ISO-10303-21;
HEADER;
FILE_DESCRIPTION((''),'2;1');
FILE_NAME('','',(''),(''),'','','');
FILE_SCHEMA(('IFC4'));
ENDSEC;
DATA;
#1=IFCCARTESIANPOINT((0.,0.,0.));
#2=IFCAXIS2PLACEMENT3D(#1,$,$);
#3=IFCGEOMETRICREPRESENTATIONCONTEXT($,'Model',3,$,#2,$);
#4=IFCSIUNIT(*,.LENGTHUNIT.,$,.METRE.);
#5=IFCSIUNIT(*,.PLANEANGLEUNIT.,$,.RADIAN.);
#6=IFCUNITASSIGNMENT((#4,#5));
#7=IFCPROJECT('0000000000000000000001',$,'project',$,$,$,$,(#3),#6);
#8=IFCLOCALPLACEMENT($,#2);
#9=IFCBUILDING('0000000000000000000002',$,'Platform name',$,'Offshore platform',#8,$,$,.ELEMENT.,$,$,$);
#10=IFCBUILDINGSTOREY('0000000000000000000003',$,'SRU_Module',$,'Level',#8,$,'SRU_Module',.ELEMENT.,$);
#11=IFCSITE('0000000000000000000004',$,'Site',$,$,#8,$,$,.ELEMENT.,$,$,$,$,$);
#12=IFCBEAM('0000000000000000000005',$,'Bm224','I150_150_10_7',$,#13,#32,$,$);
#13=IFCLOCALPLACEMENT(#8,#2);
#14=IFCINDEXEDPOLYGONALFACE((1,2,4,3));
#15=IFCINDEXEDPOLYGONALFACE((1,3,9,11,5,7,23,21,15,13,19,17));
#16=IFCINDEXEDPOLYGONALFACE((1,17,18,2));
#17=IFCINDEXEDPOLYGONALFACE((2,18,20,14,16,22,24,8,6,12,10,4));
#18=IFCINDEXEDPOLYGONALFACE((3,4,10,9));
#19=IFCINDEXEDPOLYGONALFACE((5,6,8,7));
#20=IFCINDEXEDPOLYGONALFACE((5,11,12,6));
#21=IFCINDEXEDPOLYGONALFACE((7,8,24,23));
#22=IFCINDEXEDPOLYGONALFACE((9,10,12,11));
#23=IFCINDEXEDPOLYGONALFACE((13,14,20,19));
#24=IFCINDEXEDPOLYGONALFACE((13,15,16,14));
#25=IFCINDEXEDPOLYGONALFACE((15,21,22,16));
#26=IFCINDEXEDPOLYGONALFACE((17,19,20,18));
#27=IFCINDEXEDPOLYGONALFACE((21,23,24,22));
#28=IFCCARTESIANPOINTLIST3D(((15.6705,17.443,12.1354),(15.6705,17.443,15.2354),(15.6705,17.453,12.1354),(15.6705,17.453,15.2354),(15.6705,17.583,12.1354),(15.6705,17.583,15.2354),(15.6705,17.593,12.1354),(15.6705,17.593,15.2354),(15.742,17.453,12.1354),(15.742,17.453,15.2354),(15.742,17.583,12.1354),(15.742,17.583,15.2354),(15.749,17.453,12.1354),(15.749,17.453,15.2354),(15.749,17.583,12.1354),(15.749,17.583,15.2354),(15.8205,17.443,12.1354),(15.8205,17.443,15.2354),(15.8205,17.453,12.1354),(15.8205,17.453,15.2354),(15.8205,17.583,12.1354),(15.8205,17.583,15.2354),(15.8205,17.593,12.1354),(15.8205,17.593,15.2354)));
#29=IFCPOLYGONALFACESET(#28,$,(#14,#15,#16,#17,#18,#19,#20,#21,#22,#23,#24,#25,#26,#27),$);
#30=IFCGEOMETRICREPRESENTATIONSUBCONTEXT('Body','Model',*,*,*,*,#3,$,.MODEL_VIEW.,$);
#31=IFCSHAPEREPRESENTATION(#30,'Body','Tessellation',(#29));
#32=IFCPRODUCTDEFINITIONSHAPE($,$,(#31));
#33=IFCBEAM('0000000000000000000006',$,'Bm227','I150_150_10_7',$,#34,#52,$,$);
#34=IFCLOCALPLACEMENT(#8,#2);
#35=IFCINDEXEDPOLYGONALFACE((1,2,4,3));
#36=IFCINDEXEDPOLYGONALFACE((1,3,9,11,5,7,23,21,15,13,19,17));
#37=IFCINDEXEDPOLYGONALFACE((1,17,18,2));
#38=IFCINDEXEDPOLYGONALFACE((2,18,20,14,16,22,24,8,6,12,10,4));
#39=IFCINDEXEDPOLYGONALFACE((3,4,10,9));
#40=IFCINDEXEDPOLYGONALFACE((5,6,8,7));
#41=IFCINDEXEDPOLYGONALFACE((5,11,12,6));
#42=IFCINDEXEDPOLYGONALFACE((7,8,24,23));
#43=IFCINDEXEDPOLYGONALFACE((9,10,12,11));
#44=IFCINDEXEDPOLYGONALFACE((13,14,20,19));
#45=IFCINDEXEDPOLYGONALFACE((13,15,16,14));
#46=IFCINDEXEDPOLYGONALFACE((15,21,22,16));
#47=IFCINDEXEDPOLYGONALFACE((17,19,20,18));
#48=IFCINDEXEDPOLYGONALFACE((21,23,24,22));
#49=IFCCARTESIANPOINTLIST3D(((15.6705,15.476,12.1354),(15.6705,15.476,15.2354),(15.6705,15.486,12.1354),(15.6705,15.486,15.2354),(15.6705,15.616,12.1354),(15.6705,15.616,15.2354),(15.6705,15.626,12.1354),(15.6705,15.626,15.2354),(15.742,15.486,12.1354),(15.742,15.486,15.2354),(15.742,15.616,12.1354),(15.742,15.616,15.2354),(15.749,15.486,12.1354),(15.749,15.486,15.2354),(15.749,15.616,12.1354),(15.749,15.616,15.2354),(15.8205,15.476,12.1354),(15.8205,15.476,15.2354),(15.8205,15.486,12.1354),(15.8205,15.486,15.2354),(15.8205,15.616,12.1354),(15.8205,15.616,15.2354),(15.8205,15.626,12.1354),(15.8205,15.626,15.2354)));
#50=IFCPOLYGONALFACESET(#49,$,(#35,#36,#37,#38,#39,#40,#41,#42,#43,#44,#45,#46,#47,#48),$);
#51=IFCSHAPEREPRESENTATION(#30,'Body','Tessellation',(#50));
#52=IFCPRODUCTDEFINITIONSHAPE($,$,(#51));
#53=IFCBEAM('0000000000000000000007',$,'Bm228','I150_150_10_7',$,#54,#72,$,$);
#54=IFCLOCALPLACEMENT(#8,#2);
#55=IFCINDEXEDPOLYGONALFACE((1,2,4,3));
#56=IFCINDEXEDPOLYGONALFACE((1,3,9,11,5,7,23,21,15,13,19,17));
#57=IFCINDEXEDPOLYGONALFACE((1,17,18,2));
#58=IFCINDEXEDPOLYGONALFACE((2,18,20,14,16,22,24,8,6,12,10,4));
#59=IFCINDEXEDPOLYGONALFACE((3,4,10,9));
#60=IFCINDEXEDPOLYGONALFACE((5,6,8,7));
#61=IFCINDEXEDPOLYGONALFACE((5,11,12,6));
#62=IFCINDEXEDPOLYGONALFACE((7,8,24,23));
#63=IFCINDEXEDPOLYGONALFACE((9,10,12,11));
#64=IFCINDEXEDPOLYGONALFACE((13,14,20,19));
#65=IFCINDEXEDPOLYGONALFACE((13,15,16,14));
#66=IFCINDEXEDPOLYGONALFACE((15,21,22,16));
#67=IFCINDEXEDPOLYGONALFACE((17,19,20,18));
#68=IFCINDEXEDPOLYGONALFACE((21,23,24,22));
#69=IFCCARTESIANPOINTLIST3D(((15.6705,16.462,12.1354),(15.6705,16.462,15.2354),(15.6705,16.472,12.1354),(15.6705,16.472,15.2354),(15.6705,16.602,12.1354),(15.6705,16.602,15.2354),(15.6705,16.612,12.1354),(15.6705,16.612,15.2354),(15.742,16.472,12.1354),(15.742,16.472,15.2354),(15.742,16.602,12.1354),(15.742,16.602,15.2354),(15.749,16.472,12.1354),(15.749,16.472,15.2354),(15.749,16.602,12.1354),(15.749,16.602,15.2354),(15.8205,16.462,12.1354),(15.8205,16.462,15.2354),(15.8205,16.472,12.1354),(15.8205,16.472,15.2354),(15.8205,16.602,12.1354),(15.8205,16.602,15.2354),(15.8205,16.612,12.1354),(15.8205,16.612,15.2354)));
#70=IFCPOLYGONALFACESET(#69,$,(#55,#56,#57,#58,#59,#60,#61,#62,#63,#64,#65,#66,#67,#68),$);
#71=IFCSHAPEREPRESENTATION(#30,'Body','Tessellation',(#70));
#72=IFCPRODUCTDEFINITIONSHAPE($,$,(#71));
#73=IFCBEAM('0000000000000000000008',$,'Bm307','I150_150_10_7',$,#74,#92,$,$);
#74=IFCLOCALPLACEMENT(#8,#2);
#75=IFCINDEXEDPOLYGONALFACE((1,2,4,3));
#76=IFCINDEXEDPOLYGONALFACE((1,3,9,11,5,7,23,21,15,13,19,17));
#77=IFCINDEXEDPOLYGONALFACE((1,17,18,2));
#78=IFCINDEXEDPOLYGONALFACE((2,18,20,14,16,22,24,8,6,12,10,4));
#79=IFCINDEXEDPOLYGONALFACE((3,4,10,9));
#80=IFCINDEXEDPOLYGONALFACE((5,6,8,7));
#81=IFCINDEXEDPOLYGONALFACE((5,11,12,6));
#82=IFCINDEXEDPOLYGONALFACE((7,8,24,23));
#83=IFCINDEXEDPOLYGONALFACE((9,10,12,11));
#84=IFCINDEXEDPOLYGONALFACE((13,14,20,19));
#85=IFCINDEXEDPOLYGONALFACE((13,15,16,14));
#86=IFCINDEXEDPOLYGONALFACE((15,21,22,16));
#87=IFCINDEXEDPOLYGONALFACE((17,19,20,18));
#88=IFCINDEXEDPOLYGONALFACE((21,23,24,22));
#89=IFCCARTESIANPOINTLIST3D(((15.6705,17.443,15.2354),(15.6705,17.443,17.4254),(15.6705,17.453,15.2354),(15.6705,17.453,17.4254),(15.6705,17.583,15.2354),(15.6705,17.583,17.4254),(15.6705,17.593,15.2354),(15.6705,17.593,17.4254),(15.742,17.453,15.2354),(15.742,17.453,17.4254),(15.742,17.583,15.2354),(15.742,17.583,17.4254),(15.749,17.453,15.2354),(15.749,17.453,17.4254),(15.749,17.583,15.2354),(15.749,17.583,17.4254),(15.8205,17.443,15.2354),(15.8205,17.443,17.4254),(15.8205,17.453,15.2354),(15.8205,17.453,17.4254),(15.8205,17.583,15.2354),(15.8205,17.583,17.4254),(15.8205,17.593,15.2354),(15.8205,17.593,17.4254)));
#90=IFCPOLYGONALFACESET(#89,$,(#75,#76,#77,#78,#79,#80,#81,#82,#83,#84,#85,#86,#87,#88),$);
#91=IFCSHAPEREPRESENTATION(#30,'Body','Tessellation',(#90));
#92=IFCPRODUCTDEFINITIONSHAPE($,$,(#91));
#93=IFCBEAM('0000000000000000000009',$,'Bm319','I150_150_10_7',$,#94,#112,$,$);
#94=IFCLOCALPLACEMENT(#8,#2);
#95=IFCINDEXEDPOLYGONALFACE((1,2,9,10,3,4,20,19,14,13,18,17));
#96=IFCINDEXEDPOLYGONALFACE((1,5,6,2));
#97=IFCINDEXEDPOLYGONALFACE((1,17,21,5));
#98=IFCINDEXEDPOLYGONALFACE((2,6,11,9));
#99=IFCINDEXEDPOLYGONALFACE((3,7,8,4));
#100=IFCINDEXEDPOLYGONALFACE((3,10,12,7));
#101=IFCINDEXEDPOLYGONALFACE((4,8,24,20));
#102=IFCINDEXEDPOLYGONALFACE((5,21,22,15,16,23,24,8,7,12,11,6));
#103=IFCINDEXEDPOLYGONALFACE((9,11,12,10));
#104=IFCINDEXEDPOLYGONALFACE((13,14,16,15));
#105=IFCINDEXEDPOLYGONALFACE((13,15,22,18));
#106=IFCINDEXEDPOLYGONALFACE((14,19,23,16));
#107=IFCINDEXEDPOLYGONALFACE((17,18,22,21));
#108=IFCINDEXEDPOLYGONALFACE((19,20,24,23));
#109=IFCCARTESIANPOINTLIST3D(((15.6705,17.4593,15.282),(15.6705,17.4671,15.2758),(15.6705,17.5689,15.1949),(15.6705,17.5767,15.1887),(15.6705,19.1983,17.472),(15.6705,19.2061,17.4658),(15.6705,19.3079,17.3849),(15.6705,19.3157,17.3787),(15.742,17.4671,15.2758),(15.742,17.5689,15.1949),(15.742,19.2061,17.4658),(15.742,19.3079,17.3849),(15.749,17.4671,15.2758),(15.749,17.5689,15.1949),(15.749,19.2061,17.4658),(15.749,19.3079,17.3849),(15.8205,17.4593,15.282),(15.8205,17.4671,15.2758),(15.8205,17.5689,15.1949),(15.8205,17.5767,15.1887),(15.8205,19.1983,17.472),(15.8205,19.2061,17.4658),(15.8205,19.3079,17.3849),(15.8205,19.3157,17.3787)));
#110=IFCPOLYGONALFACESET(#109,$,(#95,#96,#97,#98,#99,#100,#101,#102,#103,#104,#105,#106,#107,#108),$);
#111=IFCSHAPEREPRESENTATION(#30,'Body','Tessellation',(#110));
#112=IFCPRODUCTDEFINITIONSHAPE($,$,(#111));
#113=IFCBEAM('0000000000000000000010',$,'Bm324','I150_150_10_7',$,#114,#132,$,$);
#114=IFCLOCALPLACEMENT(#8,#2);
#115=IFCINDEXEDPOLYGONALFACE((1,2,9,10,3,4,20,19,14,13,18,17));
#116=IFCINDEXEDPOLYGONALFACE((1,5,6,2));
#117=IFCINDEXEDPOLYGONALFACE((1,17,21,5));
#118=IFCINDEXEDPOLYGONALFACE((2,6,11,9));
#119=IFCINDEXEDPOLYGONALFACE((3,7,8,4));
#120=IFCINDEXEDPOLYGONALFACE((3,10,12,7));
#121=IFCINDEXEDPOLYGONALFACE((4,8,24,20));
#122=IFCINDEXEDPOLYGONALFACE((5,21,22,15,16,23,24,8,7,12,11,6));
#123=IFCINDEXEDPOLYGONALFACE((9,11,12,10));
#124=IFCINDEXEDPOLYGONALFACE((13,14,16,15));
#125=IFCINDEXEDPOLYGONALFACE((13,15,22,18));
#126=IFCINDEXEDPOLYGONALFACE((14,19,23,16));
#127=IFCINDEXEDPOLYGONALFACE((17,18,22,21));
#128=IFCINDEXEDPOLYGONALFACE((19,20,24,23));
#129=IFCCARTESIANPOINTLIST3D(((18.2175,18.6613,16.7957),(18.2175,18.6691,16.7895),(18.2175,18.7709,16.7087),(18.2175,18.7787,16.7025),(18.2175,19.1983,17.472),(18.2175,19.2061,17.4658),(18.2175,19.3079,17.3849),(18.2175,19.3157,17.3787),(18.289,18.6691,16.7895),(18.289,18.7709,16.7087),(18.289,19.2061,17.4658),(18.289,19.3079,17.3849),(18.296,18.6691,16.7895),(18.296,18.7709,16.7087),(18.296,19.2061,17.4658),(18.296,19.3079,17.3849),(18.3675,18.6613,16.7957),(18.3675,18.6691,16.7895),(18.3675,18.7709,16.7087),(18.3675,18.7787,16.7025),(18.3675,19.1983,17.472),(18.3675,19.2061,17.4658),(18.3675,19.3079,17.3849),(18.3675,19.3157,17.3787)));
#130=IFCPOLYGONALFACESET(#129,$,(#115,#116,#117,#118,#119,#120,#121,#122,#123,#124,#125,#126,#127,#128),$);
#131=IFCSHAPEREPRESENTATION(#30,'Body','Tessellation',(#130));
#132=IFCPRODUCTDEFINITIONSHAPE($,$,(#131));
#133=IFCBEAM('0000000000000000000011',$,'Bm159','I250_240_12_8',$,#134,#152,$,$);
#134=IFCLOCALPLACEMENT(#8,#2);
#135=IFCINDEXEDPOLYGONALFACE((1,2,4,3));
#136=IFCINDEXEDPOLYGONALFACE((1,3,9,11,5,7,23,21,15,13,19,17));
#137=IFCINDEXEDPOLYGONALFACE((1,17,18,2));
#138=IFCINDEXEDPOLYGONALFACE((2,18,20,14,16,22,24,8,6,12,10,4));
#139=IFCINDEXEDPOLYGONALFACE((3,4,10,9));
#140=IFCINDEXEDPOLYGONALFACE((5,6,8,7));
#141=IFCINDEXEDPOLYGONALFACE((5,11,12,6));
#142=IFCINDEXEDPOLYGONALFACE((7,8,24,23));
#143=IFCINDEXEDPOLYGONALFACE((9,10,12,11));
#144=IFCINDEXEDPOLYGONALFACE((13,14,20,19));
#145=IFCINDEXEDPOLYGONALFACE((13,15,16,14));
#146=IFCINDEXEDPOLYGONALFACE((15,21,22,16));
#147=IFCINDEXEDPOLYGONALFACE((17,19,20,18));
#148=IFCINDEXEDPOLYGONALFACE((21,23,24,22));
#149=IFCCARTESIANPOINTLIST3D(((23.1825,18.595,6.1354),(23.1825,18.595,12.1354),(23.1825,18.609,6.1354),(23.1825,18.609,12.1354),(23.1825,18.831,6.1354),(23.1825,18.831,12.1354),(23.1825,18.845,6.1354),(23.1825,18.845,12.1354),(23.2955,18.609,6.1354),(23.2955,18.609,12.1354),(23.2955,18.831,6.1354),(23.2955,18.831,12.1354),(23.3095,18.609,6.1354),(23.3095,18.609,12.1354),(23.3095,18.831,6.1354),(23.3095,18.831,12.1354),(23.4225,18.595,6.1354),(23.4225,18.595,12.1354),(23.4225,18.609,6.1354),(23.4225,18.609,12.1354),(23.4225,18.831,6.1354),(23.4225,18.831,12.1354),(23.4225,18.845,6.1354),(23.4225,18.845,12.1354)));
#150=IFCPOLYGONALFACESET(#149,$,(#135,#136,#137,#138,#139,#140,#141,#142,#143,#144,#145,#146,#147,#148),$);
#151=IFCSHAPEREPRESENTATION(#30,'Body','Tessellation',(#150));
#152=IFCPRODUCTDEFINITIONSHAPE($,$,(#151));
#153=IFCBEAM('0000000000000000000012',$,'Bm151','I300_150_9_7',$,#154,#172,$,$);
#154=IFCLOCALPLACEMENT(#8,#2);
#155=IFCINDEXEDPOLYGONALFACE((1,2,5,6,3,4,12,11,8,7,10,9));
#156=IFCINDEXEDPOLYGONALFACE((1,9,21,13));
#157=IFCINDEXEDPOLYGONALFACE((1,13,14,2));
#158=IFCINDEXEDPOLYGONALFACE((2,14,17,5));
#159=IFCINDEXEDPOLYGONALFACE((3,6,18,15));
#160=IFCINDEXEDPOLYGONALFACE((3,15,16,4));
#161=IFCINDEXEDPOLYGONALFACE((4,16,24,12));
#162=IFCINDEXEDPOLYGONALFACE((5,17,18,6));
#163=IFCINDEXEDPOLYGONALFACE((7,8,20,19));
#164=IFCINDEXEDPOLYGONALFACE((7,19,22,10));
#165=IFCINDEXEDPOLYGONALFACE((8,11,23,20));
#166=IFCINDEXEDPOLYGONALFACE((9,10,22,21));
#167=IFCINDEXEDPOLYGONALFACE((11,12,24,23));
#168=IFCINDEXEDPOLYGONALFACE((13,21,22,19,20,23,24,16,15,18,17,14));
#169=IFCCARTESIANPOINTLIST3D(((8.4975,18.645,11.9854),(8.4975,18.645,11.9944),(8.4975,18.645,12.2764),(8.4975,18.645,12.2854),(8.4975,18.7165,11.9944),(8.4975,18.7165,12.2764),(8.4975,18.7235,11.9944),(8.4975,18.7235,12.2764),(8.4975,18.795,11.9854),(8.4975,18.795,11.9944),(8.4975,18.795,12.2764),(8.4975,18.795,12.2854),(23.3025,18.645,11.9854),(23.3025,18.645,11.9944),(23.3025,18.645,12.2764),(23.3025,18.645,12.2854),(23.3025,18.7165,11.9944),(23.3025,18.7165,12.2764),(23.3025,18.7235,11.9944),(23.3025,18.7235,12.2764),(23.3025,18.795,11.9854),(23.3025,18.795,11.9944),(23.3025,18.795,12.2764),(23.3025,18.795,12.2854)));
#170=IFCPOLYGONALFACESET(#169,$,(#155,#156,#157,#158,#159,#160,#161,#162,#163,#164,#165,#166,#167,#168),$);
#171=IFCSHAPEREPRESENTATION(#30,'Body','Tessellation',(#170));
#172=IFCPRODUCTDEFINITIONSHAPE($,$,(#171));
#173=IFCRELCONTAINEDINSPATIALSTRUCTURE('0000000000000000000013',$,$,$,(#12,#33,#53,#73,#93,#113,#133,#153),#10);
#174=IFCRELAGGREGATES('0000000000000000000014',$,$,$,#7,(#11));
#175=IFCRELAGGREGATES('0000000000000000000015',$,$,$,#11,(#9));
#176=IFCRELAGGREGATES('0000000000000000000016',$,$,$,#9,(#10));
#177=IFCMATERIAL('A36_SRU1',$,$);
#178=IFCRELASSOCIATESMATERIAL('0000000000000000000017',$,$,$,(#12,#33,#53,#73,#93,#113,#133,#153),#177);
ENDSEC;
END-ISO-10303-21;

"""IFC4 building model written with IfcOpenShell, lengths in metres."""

from ifc_helpers import new_model, si_unit, frame, origin, origin_with_axes, origin_2d, place, context, subcontext, project, spatial, i_section, extrude, source, transform, mapped, material, element, save


model = new_model("IFC4")

# Units and contexts
model_context = context("Model", 3, world=origin())
body_context = subcontext(model_context, "Body", "Model", "MODEL_VIEW")
ifc_project = project(units=[si_unit("LENGTHUNIT", "METRE"), si_unit("PLANEANGLEUNIT", "RADIAN")], contexts=[model_context])

# Site, building, storey
placement_1 = place(None, origin())
site = spatial("IfcSite", under=ifc_project, at=placement_1, Name="Site", CompositionType="ELEMENT")
building = spatial("IfcBuilding", under=site, at=placement_1, Name="Platform name", ObjectType="Offshore platform", CompositionType="ELEMENT")
storey = spatial("IfcBuildingStorey", under=building, at=placement_1, Name="SRU_Module", ObjectType="Level", LongName="SRU_Module", CompositionType="ELEMENT")

# Beams
ifc_material_1 = material(Name="A36_SRU1")
shared_shape_1 = source(origin(), body_context, "Body", "SweptSolid", [
    extrude(i_section(OverallWidth=0.15, OverallDepth=0.15, WebThickness=0.007, FlangeThickness=0.01, FilletRadius=0.0, at=origin_2d()), origin_with_axes(), (0.0, 0.0, 1.0), 3.1),
])
placement_2 = place(None, origin())
placement_3 = place(placement_2, origin())
placement_4 = place(placement_3, origin())
beam_1_placement = place(placement_4, frame((15.7455, 17.518, 12.1354)))
element("IfcBeam", 1, at=beam_1_placement, inside=storey, material=ifc_material_1, Name="Bm224", Description="I150_150_10_7", context=body_context, shape_type="MappedRepresentation", body=[
    mapped(shared_shape_1, transform((0.0, 0.0, 0.0), scale=1.0)),
])
shared_shape_2 = source(origin(), body_context, "Body", "SweptSolid", [
    extrude(i_section(OverallWidth=0.15, OverallDepth=0.15, WebThickness=0.007, FlangeThickness=0.01, FilletRadius=0.0, at=origin_2d()), origin_with_axes(), (0.0, 0.0, 1.0), 3.1),
])
placement_5 = place(None, origin())
placement_6 = place(placement_5, origin())
placement_7 = place(placement_6, origin())
beam_2_placement = place(placement_7, frame((15.7455, 15.551, 12.1354)))
element("IfcBeam", 2, at=beam_2_placement, inside=storey, material=ifc_material_1, Name="Bm227", Description="I150_150_10_7", context=body_context, shape_type="MappedRepresentation", body=[
    mapped(shared_shape_2, transform((0.0, 0.0, 0.0), scale=1.0)),
])
shared_shape_3 = source(origin(), body_context, "Body", "SweptSolid", [
    extrude(i_section(OverallWidth=0.15, OverallDepth=0.15, WebThickness=0.007, FlangeThickness=0.01, FilletRadius=0.0, at=origin_2d()), origin_with_axes(), (0.0, 0.0, 1.0), 3.1),
])
placement_8 = place(None, origin())
placement_9 = place(placement_8, origin())
placement_10 = place(placement_9, origin())
beam_3_placement = place(placement_10, frame((15.7455, 16.537, 12.1354)))
element("IfcBeam", 3, at=beam_3_placement, inside=storey, material=ifc_material_1, Name="Bm228", Description="I150_150_10_7", context=body_context, shape_type="MappedRepresentation", body=[
    mapped(shared_shape_3, transform((0.0, 0.0, 0.0), scale=1.0)),
])
shared_shape_4 = source(origin(), body_context, "Body", "SweptSolid", [
    extrude(i_section(OverallWidth=0.15, OverallDepth=0.15, WebThickness=0.007, FlangeThickness=0.01, FilletRadius=0.0, at=origin_2d()), origin_with_axes(), (0.0, 0.0, 1.0), 2.19),
])
placement_11 = place(None, origin())
placement_12 = place(placement_11, origin())
placement_13 = place(placement_12, origin())
beam_4_placement = place(placement_13, frame((15.7455, 17.518, 15.2354)))
element("IfcBeam", 4, at=beam_4_placement, inside=storey, material=ifc_material_1, Name="Bm307", Description="I150_150_10_7", context=body_context, shape_type="MappedRepresentation", body=[
    mapped(shared_shape_4, transform((0.0, 0.0, 0.0), scale=1.0)),
])
shared_shape_5 = source(origin(), body_context, "Body", "SweptSolid", [
    extrude(i_section(OverallWidth=0.15, OverallDepth=0.15, WebThickness=0.007, FlangeThickness=0.01, FilletRadius=0.0, at=origin_2d()), frame((0.0, 0.0, 0.0), z_axis=(0.0, 0.621856, 0.783131), x_axis=(-1.0, 0.0, 0.0)), (0.0, 0.0, 1.0), 2.7965),
])
placement_14 = place(None, origin())
placement_15 = place(placement_14, origin())
placement_16 = place(placement_15, origin())
beam_5_placement = place(placement_16, frame((15.7455, 17.518, 15.2354)))
element("IfcBeam", 5, at=beam_5_placement, inside=storey, material=ifc_material_1, Name="Bm319", Description="I150_150_10_7", context=body_context, shape_type="MappedRepresentation", body=[
    mapped(shared_shape_5, transform((0.0, 0.0, 0.0), scale=1.0)),
])
shared_shape_6 = source(origin(), body_context, "Body", "SweptSolid", [
    extrude(i_section(OverallWidth=0.15, OverallDepth=0.15, WebThickness=0.007, FlangeThickness=0.01, FilletRadius=0.0, at=origin_2d()), frame((0.0, 0.0, 0.0), z_axis=(0.0, 0.621856, 0.783131), x_axis=(-1.0, 0.0, 0.0)), (0.0, 0.0, 1.0), 0.8635),
])
placement_17 = place(None, origin())
placement_18 = place(placement_17, origin())
placement_19 = place(placement_18, origin())
beam_6_placement = place(placement_19, frame((18.2925, 18.72, 16.7491)))
element("IfcBeam", 6, at=beam_6_placement, inside=storey, material=ifc_material_1, Name="Bm324", Description="I150_150_10_7", context=body_context, shape_type="MappedRepresentation", body=[
    mapped(shared_shape_6, transform((0.0, 0.0, 0.0), scale=1.0)),
])
shared_shape_7 = source(origin(), body_context, "Body", "SweptSolid", [
    extrude(i_section(OverallWidth=0.24, OverallDepth=0.25, WebThickness=0.014, FlangeThickness=0.014, FilletRadius=0.0, at=origin_2d()), origin_with_axes(), (0.0, 0.0, 1.0), 6.0),
])
placement_20 = place(None, origin())
placement_21 = place(placement_20, origin())
placement_22 = place(placement_21, origin())
beam_7_placement = place(placement_22, frame((23.3025, 18.72, 6.1354)))
element("IfcBeam", 7, at=beam_7_placement, inside=storey, material=ifc_material_1, Name="Bm159", Description="I250_240_12_8", context=body_context, shape_type="MappedRepresentation", body=[
    mapped(shared_shape_7, transform((0.0, 0.0, 0.0), scale=1.0)),
])
shared_shape_8 = source(origin(), body_context, "Body", "SweptSolid", [
    extrude(i_section(OverallWidth=0.15, OverallDepth=0.3, WebThickness=0.007, FlangeThickness=0.009, FilletRadius=0.0, at=origin_2d()), frame((0.0, 0.0, 0.0), z_axis=(-1.0, 0.0, 0.0), x_axis=(0.0, -1.0, 0.0)), (0.0, 0.0, 1.0), 14.805),
])
placement_23 = place(None, origin())
placement_24 = place(placement_23, origin())
placement_25 = place(placement_24, origin())
beam_8_placement = place(placement_25, frame((23.3025, 18.72, 12.1354)))
element("IfcBeam", 8, at=beam_8_placement, inside=storey, material=ifc_material_1, Name="Bm151", Description="I300_150_9_7", context=body_context, shape_type="MappedRepresentation", body=[
    mapped(shared_shape_8, transform((0.0, 0.0, 0.0), scale=1.0)),
])

save(model, "model.ifc")
